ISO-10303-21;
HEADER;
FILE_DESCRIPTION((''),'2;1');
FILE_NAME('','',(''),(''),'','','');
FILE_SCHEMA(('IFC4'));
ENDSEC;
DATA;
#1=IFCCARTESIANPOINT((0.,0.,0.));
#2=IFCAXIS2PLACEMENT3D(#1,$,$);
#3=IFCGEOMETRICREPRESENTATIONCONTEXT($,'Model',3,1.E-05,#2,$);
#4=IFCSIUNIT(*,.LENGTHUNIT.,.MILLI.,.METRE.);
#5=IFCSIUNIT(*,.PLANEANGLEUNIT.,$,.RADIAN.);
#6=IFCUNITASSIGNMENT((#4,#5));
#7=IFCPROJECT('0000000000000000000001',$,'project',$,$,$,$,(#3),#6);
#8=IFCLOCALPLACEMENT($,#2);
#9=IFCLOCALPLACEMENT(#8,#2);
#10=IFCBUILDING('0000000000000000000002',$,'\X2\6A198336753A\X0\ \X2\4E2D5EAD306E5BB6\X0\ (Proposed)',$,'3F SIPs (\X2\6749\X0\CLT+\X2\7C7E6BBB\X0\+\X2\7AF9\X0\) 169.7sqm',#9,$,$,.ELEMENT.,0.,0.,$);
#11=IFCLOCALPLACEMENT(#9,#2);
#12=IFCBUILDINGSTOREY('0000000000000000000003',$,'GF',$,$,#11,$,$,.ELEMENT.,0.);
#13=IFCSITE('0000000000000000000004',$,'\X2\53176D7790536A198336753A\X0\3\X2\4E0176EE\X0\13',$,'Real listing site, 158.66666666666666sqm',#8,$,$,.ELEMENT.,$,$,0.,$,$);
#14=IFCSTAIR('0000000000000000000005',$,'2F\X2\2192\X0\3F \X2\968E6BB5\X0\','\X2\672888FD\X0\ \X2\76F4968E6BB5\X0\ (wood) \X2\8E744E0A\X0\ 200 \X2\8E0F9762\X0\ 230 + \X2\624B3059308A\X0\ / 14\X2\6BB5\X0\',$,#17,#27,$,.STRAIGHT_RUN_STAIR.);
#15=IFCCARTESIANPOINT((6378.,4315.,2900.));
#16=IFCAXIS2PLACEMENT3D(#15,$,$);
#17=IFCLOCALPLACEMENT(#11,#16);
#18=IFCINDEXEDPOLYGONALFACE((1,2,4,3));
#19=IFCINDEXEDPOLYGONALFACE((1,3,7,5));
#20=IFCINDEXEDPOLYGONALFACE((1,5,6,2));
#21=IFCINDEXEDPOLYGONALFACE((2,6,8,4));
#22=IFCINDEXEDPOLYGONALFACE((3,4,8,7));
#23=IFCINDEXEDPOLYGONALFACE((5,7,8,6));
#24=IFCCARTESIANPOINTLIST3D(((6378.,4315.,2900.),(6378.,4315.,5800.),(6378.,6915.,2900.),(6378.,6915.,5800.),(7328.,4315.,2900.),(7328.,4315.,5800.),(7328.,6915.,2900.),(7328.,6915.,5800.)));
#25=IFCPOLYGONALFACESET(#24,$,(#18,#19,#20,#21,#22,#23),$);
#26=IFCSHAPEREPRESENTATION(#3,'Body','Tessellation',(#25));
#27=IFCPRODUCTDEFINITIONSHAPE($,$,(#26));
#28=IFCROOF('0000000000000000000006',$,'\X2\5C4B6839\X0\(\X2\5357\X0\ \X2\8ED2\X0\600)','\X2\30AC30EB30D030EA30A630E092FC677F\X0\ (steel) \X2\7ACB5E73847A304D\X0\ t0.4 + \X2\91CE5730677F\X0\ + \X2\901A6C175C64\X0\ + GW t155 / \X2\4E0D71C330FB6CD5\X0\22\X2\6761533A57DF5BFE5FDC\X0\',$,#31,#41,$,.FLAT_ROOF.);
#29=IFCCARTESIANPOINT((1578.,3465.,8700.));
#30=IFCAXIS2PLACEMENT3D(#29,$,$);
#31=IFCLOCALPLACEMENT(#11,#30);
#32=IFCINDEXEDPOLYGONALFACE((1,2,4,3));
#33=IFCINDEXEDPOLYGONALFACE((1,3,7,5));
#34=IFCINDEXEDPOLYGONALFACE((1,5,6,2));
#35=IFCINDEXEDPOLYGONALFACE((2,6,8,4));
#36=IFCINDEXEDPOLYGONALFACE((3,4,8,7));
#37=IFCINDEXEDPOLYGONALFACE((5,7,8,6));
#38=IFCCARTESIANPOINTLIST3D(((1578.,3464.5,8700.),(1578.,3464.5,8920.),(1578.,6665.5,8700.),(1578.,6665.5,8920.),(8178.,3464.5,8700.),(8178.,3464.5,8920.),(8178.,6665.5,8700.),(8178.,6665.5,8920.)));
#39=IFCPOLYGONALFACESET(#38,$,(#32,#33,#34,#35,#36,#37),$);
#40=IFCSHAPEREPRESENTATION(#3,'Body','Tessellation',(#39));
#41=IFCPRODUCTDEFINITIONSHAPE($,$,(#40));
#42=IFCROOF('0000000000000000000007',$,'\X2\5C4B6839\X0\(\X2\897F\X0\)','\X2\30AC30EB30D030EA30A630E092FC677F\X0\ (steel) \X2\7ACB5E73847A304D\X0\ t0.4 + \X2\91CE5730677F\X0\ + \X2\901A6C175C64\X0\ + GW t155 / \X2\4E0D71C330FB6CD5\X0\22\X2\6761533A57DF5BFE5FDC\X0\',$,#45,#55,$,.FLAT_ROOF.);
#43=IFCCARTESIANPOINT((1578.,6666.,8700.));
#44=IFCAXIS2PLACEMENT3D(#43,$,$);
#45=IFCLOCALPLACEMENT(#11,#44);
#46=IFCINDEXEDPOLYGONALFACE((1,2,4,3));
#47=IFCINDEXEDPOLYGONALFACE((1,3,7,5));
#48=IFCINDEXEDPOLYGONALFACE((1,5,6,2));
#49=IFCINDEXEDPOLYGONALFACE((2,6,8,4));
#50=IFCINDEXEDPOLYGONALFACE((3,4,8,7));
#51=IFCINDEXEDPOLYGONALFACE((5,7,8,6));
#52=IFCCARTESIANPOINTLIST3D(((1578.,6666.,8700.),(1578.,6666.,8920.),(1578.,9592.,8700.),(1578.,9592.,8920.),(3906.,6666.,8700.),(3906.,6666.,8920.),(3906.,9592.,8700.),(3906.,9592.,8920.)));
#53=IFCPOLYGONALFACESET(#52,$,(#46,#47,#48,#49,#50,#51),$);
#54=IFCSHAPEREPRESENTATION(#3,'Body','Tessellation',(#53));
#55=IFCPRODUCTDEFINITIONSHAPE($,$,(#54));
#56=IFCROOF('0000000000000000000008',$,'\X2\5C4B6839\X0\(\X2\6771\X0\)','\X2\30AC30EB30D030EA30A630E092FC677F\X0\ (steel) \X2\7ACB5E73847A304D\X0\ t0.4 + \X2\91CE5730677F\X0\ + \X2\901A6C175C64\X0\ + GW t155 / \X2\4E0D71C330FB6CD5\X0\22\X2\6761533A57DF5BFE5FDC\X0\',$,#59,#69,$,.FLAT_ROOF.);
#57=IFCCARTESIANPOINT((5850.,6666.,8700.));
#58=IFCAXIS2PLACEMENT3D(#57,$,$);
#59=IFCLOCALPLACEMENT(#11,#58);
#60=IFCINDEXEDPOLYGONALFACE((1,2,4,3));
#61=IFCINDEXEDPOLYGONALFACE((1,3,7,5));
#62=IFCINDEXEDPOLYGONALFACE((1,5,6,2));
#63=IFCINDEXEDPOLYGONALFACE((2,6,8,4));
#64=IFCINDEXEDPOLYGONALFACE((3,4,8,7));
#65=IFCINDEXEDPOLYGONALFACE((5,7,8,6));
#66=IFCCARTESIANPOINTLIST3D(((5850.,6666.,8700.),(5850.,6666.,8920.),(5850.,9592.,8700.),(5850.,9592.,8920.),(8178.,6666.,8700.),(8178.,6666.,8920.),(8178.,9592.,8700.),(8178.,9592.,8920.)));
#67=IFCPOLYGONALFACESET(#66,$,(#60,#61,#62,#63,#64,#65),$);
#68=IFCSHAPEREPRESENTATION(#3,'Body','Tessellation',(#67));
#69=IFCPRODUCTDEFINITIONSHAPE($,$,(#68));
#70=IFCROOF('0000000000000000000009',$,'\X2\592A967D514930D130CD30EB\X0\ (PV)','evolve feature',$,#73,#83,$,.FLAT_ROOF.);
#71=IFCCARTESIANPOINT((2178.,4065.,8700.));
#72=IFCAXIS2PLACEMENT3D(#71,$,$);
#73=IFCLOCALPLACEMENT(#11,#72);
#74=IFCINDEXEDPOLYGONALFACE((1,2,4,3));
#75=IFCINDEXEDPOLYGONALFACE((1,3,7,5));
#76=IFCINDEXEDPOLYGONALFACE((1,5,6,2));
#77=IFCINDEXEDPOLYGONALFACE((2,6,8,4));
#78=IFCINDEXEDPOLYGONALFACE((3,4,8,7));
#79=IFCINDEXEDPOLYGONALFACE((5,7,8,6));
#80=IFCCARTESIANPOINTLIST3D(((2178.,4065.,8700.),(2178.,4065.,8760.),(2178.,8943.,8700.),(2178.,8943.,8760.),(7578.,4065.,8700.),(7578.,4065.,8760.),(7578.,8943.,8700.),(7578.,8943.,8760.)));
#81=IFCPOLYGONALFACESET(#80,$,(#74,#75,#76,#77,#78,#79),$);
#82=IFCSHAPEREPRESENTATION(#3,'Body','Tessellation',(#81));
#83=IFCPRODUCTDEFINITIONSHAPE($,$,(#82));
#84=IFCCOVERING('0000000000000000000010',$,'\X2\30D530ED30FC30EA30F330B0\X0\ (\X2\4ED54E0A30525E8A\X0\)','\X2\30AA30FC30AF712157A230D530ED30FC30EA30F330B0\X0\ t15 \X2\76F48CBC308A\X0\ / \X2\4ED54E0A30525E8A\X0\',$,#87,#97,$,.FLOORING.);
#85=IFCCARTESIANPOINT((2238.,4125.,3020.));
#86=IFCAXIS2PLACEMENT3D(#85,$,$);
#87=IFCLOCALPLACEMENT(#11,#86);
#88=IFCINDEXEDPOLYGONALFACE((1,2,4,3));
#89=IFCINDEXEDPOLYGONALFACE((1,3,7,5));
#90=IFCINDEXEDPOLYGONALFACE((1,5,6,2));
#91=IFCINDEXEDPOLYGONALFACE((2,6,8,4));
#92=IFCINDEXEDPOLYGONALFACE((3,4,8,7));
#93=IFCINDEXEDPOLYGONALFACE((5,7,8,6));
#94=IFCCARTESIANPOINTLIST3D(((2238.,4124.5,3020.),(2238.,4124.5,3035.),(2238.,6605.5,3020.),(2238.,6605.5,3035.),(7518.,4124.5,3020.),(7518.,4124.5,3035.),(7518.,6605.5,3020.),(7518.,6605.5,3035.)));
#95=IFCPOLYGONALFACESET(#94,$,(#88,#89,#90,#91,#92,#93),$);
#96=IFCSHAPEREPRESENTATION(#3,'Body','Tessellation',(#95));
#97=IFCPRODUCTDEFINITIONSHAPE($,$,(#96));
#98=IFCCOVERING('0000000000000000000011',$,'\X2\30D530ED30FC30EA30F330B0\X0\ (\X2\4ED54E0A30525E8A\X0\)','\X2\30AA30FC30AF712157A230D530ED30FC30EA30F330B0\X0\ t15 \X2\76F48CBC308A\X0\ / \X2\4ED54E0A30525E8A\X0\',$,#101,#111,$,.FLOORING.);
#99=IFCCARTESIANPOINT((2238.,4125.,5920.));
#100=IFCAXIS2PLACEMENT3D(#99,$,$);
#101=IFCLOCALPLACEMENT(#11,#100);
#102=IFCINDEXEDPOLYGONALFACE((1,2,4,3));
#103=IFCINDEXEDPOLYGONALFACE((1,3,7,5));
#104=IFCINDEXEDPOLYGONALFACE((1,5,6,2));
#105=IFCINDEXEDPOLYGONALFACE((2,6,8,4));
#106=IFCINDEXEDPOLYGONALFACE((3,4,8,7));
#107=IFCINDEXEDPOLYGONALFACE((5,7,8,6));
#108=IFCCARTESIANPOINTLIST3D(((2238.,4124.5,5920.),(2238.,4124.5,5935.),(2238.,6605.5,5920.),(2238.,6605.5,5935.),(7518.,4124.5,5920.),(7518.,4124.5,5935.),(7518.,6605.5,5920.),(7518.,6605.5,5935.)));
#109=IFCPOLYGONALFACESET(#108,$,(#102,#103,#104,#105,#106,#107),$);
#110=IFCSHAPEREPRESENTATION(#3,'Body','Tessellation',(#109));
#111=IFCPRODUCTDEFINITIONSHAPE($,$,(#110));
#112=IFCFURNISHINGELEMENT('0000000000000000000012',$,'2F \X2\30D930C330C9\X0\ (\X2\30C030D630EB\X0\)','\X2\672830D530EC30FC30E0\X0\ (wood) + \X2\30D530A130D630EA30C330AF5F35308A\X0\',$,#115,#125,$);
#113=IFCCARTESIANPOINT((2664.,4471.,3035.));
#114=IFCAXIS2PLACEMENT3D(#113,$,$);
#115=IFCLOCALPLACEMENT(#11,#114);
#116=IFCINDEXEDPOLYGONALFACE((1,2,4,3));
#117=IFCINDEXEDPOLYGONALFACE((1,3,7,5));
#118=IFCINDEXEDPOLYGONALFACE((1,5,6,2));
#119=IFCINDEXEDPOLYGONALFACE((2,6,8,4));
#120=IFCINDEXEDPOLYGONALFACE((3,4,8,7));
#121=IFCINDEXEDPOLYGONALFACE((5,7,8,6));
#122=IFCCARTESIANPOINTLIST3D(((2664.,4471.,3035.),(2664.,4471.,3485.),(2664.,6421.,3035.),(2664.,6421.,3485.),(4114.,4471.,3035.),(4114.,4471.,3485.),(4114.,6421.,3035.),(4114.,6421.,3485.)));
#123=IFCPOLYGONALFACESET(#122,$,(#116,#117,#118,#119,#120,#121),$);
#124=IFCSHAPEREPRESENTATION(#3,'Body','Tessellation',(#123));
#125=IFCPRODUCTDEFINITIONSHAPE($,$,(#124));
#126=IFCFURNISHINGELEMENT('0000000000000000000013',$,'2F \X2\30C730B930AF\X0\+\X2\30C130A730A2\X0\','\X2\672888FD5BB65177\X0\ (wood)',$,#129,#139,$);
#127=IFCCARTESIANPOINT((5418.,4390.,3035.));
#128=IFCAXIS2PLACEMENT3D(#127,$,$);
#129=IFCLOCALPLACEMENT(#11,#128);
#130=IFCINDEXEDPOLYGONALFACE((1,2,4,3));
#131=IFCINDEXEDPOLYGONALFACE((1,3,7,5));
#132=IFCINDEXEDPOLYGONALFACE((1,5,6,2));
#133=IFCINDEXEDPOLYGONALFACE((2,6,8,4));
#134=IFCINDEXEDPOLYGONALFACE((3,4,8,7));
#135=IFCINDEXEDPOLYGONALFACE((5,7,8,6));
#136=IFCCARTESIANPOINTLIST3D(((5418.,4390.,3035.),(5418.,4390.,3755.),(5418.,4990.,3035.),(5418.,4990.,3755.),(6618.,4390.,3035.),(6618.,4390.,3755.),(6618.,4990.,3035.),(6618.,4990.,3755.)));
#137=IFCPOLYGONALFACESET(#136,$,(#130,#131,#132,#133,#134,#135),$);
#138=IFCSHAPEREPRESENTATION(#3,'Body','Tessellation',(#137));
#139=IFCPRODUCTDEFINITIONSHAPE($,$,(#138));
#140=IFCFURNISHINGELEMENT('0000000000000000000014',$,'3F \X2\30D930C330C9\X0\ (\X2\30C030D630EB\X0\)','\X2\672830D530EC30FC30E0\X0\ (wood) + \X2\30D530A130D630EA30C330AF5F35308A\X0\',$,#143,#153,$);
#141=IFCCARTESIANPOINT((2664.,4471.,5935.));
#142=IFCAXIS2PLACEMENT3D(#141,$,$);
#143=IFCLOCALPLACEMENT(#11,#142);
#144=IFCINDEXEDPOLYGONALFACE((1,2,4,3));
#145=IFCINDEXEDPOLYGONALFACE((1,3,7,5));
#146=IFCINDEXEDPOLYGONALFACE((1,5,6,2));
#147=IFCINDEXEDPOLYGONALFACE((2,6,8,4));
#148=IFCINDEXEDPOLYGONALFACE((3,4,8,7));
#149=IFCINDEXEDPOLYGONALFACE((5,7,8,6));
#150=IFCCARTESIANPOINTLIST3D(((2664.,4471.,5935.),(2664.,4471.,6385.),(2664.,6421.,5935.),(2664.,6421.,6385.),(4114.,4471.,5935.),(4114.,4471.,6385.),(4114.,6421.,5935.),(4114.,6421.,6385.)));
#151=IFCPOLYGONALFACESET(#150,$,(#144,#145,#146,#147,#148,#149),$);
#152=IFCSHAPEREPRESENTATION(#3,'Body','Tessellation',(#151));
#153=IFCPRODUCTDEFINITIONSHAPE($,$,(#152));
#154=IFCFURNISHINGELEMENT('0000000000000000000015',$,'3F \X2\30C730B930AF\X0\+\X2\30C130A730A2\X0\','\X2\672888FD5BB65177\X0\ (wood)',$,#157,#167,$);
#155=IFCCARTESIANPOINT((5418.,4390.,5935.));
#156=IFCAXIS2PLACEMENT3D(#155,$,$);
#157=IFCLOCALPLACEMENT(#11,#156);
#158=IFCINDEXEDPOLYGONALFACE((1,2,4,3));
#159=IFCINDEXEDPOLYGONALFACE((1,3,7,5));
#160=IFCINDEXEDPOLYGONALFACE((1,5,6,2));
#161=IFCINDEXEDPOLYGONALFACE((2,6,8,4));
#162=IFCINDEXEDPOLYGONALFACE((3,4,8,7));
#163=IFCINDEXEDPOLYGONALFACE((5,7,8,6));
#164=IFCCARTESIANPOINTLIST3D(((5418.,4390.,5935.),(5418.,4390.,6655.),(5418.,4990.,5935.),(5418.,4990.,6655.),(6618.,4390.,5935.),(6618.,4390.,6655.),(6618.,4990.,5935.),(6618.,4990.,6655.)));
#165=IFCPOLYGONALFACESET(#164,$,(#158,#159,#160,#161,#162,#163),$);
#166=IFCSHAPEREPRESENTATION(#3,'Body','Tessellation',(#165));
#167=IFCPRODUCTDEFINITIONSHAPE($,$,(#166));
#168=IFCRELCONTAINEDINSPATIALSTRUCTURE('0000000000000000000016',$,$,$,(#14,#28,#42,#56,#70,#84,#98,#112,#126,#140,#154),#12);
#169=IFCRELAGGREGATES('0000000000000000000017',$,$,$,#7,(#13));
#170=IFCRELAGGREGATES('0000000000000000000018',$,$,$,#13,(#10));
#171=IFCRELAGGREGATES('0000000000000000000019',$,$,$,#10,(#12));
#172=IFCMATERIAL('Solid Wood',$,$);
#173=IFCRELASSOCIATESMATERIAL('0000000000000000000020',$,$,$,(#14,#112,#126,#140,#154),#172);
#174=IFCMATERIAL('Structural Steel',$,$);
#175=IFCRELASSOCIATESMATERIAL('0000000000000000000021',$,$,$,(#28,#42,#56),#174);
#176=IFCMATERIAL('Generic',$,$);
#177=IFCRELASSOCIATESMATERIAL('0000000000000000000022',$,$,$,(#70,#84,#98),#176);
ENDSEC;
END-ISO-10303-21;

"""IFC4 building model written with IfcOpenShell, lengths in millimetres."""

from ifc_helpers import new_model, si_unit, frame, frame_2d, origin, place, context, project, spatial, rectangle, extrude, material, element, save


model = new_model("IFC4")

# Units and contexts
model_context = context("Model", 3, precision=1e-05, world=origin())
ifc_project = project(units=[si_unit("LENGTHUNIT", "METRE", prefix="MILLI"), si_unit("PLANEANGLEUNIT", "RADIAN")], contexts=[model_context])

# Site, building, storey
site_placement = place(None, origin())
site = spatial("IfcSite", under=ifc_project, at=site_placement, Name="北海道標茶町3丁目13", ObjectType="Real listing site, 158.66666666666666sqm", CompositionType="ELEMENT", RefElevation=0.0)
building_placement = place(site_placement, origin())
building = spatial("IfcBuilding", under=site, at=building_placement, Name="標茶町 中庭の家 (Proposed)", ObjectType="3F SIPs (杉CLT+籾殻+竹) 169.7sqm", CompositionType="ELEMENT", ElevationOfRefHeight=0.0, ElevationOfTerrain=0.0)
storey_placement = place(building_placement, origin())
storey = spatial("IfcBuildingStorey", under=building, at=storey_placement, Name="GF", CompositionType="ELEMENT", Elevation=0.0)

# Shared definitions
ifc_material_1 = material(Name="Solid Wood")

# Stair
stair_placement = place(storey_placement, frame((6378.0, 4315.0, 2900.0)))
element("IfcStair", 1, at=stair_placement, inside=storey, material=ifc_material_1, Name="2F→3F 階段", Description="木製 直階段 (wood) 蹴上 200 踏面 230 + 手すり / 14段", PredefinedType="STRAIGHT_RUN_STAIR", context=model_context, shape_type="SweptSolid", body=[
    extrude(rectangle(XDim=950.0, YDim=2600.0, at=frame_2d((475.0, 1300.0))), frame((6378.0, 4315.0, 2900.0)), (0.0, 0.0, 1.0), 2900.0),
])

# Roofs
ifc_material_2 = material(Name="Structural Steel")
roof_1_placement = place(storey_placement, frame((1578.0, 3465.0, 8700.0)))
element("IfcRoof", 2, at=roof_1_placement, inside=storey, material=ifc_material_2, Name="屋根(南 軒600)", Description="ガルバリウム鋼板 (steel) 立平葺き t0.4 + 野地板 + 通気層 + GW t155 / 不燃・法22条区域対応", PredefinedType="FLAT_ROOF", context=model_context, shape_type="SweptSolid", body=[
    extrude(rectangle(XDim=6600.0, YDim=3201.0, at=frame_2d((3300.0, 1600.0))), frame((1578.0, 3465.0, 8700.0)), (0.0, 0.0, 1.0), 220.0),
])
roof_2_placement = place(storey_placement, frame((1578.0, 6666.0, 8700.0)))
element("IfcRoof", 3, at=roof_2_placement, inside=storey, material=ifc_material_2, Name="屋根(西)", Description="ガルバリウム鋼板 (steel) 立平葺き t0.4 + 野地板 + 通気層 + GW t155 / 不燃・法22条区域対応", PredefinedType="FLAT_ROOF", context=model_context, shape_type="SweptSolid", body=[
    extrude(rectangle(XDim=2328.0, YDim=2926.0, at=frame_2d((1164.0, 1463.0))), frame((1578.0, 6666.0, 8700.0)), (0.0, 0.0, 1.0), 220.0),
])
roof_3_placement = place(storey_placement, frame((5850.0, 6666.0, 8700.0)))
element("IfcRoof", 4, at=roof_3_placement, inside=storey, material=ifc_material_2, Name="屋根(東)", Description="ガルバリウム鋼板 (steel) 立平葺き t0.4 + 野地板 + 通気層 + GW t155 / 不燃・法22条区域対応", PredefinedType="FLAT_ROOF", context=model_context, shape_type="SweptSolid", body=[
    extrude(rectangle(XDim=2328.0, YDim=2926.0, at=frame_2d((1164.0, 1463.0))), frame((5850.0, 6666.0, 8700.0)), (0.0, 0.0, 1.0), 220.0),
])
ifc_material_3 = material(Name="Generic")
roof_4_placement = place(storey_placement, frame((2178.0, 4065.0, 8700.0)))
element("IfcRoof", 5, at=roof_4_placement, inside=storey, material=ifc_material_3, Name="太陽光パネル (PV)", Description="evolve feature", PredefinedType="FLAT_ROOF", context=model_context, shape_type="SweptSolid", body=[
    extrude(rectangle(XDim=5400.0, YDim=4878.0, at=frame_2d((2700.0, 2439.0))), frame((2178.0, 4065.0, 8700.0)), (0.0, 0.0, 1.0), 60.0),
])

# Coverings
covering_1_placement = place(storey_placement, frame((2238.0, 4125.0, 3020.0)))
element("IfcCovering", 6, at=covering_1_placement, inside=storey, material=ifc_material_3, Name="フローリング (仕上げ床)", Description="オーク無垢フローリング t15 直貼り / 仕上げ床", PredefinedType="FLOORING", context=model_context, shape_type="SweptSolid", body=[
    extrude(rectangle(XDim=5280.0, YDim=2481.0, at=frame_2d((2640.0, 1240.0))), frame((2238.0, 4125.0, 3020.0)), (0.0, 0.0, 1.0), 15.0),
])
covering_2_placement = place(storey_placement, frame((2238.0, 4125.0, 5920.0)))
element("IfcCovering", 7, at=covering_2_placement, inside=storey, material=ifc_material_3, Name="フローリング (仕上げ床)", Description="オーク無垢フローリング t15 直貼り / 仕上げ床", PredefinedType="FLOORING", context=model_context, shape_type="SweptSolid", body=[
    extrude(rectangle(XDim=5280.0, YDim=2481.0, at=frame_2d((2640.0, 1240.0))), frame((2238.0, 4125.0, 5920.0)), (0.0, 0.0, 1.0), 15.0),
])

# Furnishing elements
furnishing_1_placement = place(storey_placement, frame((2664.0, 4471.0, 3035.0)))
element("IfcFurnishingElement", 8, at=furnishing_1_placement, inside=storey, material=ifc_material_1, Name="2F ベッド (ダブル)", Description="木フレーム (wood) + ファブリック張り", context=model_context, shape_type="SweptSolid", body=[
    extrude(rectangle(XDim=1450.0, YDim=1950.0, at=frame_2d((725.0, 975.0))), frame((2664.0, 4471.0, 3035.0)), (0.0, 0.0, 1.0), 450.0),
])
furnishing_2_placement = place(storey_placement, frame((5418.0, 4390.0, 3035.0)))
element("IfcFurnishingElement", 9, at=furnishing_2_placement, inside=storey, material=ifc_material_1, Name="2F デスク+チェア", Description="木製家具 (wood)", context=model_context, shape_type="SweptSolid", body=[
    extrude(rectangle(XDim=1200.0, YDim=600.0, at=frame_2d((600.0, 300.0))), frame((5418.0, 4390.0, 3035.0)), (0.0, 0.0, 1.0), 720.0),
])
furnishing_3_placement = place(storey_placement, frame((2664.0, 4471.0, 5935.0)))
element("IfcFurnishingElement", 10, at=furnishing_3_placement, inside=storey, material=ifc_material_1, Name="3F ベッド (ダブル)", Description="木フレーム (wood) + ファブリック張り", context=model_context, shape_type="SweptSolid", body=[
    extrude(rectangle(XDim=1450.0, YDim=1950.0, at=frame_2d((725.0, 975.0))), frame((2664.0, 4471.0, 5935.0)), (0.0, 0.0, 1.0), 450.0),
])
furnishing_4_placement = place(storey_placement, frame((5418.0, 4390.0, 5935.0)))
element("IfcFurnishingElement", 11, at=furnishing_4_placement, inside=storey, material=ifc_material_1, Name="3F デスク+チェア", Description="木製家具 (wood)", context=model_context, shape_type="SweptSolid", body=[
    extrude(rectangle(XDim=1200.0, YDim=600.0, at=frame_2d((600.0, 300.0))), frame((5418.0, 4390.0, 5935.0)), (0.0, 0.0, 1.0), 720.0),
])

save(model, "model.ifc")
